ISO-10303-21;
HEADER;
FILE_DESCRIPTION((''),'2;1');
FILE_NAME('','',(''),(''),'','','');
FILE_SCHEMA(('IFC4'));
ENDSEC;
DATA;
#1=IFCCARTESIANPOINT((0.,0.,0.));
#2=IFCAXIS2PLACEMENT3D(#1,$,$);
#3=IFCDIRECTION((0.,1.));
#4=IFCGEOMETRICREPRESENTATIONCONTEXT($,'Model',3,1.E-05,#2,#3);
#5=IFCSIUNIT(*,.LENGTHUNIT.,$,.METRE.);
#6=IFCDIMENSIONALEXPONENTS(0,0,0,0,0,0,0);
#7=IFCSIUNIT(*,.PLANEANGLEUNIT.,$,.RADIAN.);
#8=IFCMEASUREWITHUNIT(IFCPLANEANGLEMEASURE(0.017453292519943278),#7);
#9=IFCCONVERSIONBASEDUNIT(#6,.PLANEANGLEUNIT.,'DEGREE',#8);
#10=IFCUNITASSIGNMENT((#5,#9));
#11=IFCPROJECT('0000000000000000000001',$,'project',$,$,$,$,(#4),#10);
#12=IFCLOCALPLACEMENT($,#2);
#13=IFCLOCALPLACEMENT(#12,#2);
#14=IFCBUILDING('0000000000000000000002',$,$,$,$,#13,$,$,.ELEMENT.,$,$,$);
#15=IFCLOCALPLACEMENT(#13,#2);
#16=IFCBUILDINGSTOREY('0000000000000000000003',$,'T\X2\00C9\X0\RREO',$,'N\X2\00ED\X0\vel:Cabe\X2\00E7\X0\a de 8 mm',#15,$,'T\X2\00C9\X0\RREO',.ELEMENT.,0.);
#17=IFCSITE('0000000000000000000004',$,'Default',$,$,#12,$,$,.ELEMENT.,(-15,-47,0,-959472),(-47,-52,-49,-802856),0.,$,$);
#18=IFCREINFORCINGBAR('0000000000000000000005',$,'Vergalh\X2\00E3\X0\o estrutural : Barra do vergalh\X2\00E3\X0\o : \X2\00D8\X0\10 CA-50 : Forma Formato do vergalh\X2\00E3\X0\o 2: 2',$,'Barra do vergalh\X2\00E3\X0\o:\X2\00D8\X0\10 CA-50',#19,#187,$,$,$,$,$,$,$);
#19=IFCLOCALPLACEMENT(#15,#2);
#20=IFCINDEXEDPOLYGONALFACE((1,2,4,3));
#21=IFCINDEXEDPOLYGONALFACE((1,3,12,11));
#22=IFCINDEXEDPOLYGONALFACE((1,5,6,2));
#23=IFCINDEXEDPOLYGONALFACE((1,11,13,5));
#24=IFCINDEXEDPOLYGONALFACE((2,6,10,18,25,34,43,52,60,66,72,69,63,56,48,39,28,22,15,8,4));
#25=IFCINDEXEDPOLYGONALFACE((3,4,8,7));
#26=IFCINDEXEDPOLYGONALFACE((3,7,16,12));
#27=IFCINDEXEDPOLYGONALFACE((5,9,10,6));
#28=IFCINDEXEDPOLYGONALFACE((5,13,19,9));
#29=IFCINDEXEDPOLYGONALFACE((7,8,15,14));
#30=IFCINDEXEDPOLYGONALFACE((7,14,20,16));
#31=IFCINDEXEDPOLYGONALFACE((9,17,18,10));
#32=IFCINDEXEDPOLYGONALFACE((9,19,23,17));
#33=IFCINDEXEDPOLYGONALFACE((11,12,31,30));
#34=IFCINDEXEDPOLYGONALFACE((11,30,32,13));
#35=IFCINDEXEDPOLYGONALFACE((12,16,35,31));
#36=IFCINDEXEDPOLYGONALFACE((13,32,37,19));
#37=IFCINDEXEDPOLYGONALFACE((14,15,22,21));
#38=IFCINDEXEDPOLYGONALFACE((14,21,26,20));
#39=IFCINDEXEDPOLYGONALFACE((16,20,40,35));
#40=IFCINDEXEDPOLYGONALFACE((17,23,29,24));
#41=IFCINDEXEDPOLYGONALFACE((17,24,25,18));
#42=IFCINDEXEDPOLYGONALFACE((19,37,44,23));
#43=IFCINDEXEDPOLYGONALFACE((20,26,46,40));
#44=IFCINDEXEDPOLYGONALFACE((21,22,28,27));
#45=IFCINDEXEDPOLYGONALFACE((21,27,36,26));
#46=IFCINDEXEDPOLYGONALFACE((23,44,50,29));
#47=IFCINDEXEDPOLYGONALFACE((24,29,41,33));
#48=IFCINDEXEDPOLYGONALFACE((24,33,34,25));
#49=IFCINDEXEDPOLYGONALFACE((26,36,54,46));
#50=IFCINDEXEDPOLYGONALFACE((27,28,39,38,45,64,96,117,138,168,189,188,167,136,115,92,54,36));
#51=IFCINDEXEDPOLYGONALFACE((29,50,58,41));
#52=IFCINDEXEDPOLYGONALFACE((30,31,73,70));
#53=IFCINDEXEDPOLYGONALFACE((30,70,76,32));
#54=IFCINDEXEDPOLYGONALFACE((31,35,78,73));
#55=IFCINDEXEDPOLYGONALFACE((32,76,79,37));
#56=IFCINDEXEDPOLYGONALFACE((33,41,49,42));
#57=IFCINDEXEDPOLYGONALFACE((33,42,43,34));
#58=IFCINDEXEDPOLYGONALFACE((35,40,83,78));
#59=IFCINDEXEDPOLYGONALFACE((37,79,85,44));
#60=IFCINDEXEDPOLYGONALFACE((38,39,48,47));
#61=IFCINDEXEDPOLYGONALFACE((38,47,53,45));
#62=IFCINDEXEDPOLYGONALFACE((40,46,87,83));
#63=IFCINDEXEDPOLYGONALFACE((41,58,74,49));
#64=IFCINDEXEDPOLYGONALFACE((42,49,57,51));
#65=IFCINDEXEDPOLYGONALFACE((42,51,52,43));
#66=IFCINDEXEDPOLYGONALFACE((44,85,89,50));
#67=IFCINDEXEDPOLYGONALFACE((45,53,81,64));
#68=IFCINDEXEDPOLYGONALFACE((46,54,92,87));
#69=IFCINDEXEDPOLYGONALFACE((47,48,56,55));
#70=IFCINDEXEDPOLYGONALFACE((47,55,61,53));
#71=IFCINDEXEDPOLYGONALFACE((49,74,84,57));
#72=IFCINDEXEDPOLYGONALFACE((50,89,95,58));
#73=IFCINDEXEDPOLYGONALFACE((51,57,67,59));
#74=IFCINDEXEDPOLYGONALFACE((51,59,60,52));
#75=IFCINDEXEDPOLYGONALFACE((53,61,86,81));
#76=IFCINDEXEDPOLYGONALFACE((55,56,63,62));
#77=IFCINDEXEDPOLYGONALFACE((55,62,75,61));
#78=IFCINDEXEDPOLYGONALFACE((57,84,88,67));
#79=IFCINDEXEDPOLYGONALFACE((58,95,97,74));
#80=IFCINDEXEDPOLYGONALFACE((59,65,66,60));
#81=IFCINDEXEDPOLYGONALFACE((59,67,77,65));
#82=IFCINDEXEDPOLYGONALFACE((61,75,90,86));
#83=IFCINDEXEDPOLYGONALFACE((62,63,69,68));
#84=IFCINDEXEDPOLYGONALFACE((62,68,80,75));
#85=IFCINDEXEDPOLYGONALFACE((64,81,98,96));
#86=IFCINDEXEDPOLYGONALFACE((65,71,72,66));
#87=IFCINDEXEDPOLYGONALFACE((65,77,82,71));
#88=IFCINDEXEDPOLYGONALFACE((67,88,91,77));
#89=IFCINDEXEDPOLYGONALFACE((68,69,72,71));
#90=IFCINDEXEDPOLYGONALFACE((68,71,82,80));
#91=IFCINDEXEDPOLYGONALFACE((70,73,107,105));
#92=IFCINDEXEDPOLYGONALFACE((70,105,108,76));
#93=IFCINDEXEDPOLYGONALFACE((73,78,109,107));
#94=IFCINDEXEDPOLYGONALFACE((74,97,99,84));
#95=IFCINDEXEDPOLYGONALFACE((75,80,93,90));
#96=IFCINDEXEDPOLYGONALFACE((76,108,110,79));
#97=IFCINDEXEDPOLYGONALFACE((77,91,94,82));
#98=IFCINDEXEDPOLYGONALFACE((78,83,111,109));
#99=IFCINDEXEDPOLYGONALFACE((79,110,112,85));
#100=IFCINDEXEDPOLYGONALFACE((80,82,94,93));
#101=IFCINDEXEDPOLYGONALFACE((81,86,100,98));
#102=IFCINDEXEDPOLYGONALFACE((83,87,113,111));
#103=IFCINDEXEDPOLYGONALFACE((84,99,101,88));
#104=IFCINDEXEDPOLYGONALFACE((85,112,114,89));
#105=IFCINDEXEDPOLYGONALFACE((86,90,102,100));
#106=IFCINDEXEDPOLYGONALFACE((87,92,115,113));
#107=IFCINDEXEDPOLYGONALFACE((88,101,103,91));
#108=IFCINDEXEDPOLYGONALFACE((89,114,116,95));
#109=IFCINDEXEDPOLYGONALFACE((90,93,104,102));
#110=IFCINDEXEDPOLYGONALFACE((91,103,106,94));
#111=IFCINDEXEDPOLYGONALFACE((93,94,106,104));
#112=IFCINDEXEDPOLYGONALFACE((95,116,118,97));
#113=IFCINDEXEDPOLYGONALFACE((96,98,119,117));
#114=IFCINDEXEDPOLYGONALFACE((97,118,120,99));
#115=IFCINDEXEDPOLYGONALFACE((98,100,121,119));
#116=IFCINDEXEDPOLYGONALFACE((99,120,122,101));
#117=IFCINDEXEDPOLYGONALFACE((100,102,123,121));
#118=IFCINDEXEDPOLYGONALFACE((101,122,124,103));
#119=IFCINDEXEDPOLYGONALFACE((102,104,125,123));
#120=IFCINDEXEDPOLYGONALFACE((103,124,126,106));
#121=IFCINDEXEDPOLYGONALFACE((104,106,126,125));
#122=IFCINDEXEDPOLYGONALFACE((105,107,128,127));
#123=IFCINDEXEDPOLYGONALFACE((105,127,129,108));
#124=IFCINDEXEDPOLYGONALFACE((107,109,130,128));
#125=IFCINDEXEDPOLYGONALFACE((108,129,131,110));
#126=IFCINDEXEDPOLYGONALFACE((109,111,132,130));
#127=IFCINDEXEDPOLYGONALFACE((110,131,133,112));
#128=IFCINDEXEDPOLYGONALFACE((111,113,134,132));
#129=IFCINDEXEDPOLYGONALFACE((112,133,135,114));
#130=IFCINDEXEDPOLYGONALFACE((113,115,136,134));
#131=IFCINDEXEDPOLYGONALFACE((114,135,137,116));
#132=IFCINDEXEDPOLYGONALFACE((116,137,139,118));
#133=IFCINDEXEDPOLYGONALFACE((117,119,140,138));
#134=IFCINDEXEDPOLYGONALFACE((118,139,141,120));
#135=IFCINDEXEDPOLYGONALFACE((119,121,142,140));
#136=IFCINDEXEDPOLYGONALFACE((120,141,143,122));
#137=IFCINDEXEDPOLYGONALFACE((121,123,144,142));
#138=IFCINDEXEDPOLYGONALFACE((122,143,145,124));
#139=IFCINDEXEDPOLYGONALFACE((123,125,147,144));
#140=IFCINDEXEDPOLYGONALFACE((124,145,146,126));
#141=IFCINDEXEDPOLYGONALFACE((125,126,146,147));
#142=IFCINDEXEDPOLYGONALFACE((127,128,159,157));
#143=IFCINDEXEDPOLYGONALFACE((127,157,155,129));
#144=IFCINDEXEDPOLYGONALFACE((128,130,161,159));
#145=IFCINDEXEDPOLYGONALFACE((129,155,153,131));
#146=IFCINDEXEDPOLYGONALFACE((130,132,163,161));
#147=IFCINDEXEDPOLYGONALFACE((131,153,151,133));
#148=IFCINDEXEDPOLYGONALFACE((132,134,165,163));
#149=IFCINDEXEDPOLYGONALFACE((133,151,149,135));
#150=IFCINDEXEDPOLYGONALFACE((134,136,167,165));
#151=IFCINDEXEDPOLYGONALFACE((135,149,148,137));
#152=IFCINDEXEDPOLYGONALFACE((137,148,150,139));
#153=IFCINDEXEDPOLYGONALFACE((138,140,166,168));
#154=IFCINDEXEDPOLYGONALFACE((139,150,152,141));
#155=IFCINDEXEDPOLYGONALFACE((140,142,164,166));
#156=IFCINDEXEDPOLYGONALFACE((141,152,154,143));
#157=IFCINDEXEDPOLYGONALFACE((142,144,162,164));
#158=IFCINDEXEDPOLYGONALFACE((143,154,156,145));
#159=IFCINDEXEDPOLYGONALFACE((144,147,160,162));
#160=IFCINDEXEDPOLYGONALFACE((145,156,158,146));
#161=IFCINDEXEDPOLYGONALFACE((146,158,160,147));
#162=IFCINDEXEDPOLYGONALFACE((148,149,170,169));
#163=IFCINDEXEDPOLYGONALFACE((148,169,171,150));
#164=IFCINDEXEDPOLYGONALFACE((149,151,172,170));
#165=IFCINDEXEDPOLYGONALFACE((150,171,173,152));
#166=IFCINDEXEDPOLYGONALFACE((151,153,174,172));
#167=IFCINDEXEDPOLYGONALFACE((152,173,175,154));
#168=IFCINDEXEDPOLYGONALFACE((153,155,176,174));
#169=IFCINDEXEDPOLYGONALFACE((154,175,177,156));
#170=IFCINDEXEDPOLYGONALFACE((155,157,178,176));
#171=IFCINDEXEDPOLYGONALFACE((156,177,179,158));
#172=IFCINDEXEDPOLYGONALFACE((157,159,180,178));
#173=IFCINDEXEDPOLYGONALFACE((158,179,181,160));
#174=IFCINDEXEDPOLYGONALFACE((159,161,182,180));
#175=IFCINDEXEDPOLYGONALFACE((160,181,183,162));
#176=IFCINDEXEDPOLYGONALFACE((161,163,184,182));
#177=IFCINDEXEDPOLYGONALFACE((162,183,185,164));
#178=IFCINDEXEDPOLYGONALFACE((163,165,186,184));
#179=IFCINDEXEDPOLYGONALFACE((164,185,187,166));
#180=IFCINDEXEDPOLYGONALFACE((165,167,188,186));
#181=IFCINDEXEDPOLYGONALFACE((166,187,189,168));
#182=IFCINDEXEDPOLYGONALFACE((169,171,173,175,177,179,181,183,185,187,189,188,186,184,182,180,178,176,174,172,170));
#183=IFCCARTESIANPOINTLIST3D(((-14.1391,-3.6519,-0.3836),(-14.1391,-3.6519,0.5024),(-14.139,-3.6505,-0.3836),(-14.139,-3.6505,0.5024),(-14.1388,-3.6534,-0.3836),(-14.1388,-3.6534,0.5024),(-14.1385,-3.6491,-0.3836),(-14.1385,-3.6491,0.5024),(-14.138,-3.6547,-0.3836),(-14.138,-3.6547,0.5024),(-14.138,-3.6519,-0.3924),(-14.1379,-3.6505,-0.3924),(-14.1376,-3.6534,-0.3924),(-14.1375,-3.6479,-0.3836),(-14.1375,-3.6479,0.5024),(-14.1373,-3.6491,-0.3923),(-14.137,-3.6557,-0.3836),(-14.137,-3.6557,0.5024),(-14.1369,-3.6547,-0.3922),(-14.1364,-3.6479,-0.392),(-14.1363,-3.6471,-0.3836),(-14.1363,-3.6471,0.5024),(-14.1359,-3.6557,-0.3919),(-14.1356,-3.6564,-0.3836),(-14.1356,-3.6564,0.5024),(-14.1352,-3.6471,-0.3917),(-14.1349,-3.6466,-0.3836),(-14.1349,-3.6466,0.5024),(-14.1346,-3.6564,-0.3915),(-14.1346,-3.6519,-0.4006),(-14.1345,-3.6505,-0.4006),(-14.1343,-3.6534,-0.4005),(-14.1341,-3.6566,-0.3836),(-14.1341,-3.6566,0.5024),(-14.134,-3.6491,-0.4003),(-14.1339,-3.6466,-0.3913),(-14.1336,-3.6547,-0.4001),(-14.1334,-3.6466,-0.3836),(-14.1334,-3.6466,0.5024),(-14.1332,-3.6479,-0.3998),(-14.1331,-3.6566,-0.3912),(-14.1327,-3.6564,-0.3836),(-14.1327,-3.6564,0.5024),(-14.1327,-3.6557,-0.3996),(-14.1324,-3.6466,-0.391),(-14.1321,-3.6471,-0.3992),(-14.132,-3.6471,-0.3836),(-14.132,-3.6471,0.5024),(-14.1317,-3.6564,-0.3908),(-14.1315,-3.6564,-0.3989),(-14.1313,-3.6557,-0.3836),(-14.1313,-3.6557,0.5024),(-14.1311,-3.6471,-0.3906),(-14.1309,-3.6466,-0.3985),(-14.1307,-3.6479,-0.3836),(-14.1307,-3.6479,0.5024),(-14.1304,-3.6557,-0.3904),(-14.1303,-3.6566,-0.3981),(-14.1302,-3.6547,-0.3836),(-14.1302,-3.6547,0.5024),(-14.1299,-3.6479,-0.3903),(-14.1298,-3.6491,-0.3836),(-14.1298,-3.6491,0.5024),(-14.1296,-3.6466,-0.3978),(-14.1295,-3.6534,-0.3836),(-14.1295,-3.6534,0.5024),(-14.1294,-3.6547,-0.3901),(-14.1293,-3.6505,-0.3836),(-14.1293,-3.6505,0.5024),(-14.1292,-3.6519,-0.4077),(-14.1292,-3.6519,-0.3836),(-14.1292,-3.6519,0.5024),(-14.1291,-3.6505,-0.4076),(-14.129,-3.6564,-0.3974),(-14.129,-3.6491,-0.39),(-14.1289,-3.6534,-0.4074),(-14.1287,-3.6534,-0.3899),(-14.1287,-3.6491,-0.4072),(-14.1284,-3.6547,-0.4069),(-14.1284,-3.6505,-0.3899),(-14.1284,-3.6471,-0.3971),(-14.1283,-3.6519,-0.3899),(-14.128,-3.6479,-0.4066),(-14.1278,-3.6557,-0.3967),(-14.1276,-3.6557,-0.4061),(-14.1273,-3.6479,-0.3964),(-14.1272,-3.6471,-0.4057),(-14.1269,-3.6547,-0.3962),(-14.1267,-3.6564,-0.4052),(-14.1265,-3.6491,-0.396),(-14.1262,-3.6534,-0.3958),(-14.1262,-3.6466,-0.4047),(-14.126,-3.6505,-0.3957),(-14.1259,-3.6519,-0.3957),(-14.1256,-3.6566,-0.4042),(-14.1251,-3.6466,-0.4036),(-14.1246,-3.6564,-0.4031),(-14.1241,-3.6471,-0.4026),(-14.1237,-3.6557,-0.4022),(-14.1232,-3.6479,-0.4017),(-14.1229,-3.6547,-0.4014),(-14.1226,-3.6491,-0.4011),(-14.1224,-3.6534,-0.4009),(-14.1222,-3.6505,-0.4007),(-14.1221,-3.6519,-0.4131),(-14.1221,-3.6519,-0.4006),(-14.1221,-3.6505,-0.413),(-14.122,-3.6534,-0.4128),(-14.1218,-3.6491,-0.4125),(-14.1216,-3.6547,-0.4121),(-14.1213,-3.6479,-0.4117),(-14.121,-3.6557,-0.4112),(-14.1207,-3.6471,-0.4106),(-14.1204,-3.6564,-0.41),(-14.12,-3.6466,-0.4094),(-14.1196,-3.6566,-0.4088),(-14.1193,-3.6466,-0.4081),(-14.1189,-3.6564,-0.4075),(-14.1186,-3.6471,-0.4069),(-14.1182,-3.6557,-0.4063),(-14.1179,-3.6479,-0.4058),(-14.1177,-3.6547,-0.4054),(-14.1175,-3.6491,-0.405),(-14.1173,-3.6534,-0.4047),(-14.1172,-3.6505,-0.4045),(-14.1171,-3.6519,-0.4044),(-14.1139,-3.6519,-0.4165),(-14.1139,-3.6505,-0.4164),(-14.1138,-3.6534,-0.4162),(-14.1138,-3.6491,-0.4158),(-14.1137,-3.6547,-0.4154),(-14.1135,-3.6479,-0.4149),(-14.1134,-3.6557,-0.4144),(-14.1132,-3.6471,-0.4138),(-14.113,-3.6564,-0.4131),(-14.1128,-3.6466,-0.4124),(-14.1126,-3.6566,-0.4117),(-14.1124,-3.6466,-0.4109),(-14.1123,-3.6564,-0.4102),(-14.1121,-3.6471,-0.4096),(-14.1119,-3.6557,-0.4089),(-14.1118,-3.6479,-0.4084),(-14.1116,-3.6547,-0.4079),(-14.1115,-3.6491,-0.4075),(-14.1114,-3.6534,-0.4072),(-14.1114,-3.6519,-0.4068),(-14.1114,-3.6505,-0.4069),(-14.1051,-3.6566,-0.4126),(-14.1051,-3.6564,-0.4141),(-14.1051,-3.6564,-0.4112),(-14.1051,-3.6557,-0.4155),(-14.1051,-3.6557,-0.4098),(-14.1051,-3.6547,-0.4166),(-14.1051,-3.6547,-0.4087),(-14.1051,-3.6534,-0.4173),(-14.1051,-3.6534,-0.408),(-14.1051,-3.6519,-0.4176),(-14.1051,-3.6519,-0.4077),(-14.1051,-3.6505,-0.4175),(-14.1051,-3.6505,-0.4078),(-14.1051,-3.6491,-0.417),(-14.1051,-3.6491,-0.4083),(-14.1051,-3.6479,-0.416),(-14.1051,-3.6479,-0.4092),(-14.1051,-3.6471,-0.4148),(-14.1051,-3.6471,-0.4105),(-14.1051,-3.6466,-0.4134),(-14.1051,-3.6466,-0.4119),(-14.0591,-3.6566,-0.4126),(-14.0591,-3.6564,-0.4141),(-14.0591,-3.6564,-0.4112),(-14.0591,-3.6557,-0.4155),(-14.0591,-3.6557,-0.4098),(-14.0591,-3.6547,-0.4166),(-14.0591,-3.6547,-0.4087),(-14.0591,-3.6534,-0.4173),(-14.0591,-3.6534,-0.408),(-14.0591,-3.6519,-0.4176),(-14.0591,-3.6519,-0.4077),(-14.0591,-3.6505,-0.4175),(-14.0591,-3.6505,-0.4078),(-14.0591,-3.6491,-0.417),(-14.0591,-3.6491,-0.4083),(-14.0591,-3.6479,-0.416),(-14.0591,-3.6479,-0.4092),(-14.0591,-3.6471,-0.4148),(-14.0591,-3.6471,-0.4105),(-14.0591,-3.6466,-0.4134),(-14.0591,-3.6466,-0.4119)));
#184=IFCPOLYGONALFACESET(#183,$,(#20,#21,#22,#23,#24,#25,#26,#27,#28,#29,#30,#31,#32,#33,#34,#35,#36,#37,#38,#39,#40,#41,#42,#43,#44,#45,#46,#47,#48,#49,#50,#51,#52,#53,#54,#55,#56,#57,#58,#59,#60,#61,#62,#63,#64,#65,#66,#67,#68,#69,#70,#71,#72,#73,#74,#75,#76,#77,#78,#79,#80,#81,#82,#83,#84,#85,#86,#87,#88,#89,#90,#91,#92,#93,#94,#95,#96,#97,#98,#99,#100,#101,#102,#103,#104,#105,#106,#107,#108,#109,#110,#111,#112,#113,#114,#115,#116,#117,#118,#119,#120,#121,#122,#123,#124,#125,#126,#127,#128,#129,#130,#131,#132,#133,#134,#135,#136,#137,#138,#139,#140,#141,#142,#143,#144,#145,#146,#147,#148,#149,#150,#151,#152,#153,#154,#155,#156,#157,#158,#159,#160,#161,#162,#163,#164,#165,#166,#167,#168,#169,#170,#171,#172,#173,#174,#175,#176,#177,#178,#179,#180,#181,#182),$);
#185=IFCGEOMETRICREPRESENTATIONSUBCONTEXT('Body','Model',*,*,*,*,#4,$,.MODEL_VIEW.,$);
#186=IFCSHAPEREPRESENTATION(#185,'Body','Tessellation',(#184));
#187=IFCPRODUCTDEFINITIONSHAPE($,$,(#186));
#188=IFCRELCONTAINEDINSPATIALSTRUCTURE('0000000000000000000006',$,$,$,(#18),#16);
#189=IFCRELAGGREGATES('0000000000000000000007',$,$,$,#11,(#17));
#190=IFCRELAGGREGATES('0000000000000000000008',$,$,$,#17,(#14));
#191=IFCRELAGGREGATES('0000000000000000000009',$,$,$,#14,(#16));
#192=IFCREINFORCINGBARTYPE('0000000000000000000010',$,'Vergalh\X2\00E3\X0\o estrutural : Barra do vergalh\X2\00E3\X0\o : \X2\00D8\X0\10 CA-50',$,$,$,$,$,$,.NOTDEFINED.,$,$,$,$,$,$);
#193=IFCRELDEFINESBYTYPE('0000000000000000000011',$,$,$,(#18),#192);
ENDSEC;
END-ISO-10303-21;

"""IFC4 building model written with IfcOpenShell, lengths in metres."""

from ifc_helpers import new_model, entity, si_unit, converted_unit, direction, origin, place, context, subcontext, project, spatial, type_object, element, save


model = new_model("IFC4")

# Units and contexts
model_context = context("Model", 3, precision=1e-05, world=origin(), true_north=direction((0.0, 1.0)))
body_context = subcontext(model_context, "Body", "Model", "MODEL_VIEW")
ifc_project = project(units=[si_unit("LENGTHUNIT", "METRE"), converted_unit("PLANEANGLEUNIT", "DEGREE", entity("IfcPlaneAngleMeasure", 0.017453292519943278), si_unit("PLANEANGLEUNIT", "RADIAN"), dimensions=[0, 0, 0, 0, 0, 0, 0])], contexts=[model_context])

# Site, building, storey
site_placement = place(None, origin())
site = spatial("IfcSite", under=ifc_project, at=site_placement, Name="Default", CompositionType="ELEMENT", RefLatitude=(-15, -47, 0, -959472), RefLongitude=(-47, -52, -49, -802856), RefElevation=0.0)
building_placement = place(site_placement, origin())
building = spatial("IfcBuilding", under=site, at=building_placement, CompositionType="ELEMENT")
storey_placement = place(building_placement, origin())
storey = spatial("IfcBuildingStorey", under=building, at=storey_placement, Name="TÉRREO", ObjectType="Nível:Cabeça de 8 mm", LongName="TÉRREO", CompositionType="ELEMENT", Elevation=0.0)

# Reinforcing bar
reinforcing_bar_type_1 = type_object("IfcReinforcingBarType", Name="Vergalhão estrutural : Barra do vergalhão : Ø10 CA-50", PredefinedType="NOTDEFINED")
reinforcing_bar_1_placement = place(storey_placement, origin())
element("IfcReinforcingBar", 1, at=reinforcing_bar_1_placement, inside=storey, type_object=reinforcing_bar_type_1, Name="Vergalhão estrutural : Barra do vergalhão : Ø10 CA-50 : Forma Formato do vergalhão 2: 2", ObjectType="Barra do vergalhão:Ø10 CA-50", context=body_context, shape_type="AdvancedSweptSolid", body=[
    entity("IfcSweptDiskSolid", entity("IfcIndexedPolyCurve", entity("IfcCartesianPointList3D", [[-14.0591, -3.6516, -0.4126], [-14.1051, -3.6516, -0.4126], [-14.1256, -3.6516, -0.4042], [-14.1341, -3.6516, -0.3836], [-14.1341, -3.6516, 0.5024]]), [entity("IfcLineIndex", [1, 2]), entity("IfcArcIndex", [2, 3, 4]), entity("IfcLineIndex", [4, 5])], False), 0.005, None, 0.0, 92.0),
])

save(model, "model.ifc")
